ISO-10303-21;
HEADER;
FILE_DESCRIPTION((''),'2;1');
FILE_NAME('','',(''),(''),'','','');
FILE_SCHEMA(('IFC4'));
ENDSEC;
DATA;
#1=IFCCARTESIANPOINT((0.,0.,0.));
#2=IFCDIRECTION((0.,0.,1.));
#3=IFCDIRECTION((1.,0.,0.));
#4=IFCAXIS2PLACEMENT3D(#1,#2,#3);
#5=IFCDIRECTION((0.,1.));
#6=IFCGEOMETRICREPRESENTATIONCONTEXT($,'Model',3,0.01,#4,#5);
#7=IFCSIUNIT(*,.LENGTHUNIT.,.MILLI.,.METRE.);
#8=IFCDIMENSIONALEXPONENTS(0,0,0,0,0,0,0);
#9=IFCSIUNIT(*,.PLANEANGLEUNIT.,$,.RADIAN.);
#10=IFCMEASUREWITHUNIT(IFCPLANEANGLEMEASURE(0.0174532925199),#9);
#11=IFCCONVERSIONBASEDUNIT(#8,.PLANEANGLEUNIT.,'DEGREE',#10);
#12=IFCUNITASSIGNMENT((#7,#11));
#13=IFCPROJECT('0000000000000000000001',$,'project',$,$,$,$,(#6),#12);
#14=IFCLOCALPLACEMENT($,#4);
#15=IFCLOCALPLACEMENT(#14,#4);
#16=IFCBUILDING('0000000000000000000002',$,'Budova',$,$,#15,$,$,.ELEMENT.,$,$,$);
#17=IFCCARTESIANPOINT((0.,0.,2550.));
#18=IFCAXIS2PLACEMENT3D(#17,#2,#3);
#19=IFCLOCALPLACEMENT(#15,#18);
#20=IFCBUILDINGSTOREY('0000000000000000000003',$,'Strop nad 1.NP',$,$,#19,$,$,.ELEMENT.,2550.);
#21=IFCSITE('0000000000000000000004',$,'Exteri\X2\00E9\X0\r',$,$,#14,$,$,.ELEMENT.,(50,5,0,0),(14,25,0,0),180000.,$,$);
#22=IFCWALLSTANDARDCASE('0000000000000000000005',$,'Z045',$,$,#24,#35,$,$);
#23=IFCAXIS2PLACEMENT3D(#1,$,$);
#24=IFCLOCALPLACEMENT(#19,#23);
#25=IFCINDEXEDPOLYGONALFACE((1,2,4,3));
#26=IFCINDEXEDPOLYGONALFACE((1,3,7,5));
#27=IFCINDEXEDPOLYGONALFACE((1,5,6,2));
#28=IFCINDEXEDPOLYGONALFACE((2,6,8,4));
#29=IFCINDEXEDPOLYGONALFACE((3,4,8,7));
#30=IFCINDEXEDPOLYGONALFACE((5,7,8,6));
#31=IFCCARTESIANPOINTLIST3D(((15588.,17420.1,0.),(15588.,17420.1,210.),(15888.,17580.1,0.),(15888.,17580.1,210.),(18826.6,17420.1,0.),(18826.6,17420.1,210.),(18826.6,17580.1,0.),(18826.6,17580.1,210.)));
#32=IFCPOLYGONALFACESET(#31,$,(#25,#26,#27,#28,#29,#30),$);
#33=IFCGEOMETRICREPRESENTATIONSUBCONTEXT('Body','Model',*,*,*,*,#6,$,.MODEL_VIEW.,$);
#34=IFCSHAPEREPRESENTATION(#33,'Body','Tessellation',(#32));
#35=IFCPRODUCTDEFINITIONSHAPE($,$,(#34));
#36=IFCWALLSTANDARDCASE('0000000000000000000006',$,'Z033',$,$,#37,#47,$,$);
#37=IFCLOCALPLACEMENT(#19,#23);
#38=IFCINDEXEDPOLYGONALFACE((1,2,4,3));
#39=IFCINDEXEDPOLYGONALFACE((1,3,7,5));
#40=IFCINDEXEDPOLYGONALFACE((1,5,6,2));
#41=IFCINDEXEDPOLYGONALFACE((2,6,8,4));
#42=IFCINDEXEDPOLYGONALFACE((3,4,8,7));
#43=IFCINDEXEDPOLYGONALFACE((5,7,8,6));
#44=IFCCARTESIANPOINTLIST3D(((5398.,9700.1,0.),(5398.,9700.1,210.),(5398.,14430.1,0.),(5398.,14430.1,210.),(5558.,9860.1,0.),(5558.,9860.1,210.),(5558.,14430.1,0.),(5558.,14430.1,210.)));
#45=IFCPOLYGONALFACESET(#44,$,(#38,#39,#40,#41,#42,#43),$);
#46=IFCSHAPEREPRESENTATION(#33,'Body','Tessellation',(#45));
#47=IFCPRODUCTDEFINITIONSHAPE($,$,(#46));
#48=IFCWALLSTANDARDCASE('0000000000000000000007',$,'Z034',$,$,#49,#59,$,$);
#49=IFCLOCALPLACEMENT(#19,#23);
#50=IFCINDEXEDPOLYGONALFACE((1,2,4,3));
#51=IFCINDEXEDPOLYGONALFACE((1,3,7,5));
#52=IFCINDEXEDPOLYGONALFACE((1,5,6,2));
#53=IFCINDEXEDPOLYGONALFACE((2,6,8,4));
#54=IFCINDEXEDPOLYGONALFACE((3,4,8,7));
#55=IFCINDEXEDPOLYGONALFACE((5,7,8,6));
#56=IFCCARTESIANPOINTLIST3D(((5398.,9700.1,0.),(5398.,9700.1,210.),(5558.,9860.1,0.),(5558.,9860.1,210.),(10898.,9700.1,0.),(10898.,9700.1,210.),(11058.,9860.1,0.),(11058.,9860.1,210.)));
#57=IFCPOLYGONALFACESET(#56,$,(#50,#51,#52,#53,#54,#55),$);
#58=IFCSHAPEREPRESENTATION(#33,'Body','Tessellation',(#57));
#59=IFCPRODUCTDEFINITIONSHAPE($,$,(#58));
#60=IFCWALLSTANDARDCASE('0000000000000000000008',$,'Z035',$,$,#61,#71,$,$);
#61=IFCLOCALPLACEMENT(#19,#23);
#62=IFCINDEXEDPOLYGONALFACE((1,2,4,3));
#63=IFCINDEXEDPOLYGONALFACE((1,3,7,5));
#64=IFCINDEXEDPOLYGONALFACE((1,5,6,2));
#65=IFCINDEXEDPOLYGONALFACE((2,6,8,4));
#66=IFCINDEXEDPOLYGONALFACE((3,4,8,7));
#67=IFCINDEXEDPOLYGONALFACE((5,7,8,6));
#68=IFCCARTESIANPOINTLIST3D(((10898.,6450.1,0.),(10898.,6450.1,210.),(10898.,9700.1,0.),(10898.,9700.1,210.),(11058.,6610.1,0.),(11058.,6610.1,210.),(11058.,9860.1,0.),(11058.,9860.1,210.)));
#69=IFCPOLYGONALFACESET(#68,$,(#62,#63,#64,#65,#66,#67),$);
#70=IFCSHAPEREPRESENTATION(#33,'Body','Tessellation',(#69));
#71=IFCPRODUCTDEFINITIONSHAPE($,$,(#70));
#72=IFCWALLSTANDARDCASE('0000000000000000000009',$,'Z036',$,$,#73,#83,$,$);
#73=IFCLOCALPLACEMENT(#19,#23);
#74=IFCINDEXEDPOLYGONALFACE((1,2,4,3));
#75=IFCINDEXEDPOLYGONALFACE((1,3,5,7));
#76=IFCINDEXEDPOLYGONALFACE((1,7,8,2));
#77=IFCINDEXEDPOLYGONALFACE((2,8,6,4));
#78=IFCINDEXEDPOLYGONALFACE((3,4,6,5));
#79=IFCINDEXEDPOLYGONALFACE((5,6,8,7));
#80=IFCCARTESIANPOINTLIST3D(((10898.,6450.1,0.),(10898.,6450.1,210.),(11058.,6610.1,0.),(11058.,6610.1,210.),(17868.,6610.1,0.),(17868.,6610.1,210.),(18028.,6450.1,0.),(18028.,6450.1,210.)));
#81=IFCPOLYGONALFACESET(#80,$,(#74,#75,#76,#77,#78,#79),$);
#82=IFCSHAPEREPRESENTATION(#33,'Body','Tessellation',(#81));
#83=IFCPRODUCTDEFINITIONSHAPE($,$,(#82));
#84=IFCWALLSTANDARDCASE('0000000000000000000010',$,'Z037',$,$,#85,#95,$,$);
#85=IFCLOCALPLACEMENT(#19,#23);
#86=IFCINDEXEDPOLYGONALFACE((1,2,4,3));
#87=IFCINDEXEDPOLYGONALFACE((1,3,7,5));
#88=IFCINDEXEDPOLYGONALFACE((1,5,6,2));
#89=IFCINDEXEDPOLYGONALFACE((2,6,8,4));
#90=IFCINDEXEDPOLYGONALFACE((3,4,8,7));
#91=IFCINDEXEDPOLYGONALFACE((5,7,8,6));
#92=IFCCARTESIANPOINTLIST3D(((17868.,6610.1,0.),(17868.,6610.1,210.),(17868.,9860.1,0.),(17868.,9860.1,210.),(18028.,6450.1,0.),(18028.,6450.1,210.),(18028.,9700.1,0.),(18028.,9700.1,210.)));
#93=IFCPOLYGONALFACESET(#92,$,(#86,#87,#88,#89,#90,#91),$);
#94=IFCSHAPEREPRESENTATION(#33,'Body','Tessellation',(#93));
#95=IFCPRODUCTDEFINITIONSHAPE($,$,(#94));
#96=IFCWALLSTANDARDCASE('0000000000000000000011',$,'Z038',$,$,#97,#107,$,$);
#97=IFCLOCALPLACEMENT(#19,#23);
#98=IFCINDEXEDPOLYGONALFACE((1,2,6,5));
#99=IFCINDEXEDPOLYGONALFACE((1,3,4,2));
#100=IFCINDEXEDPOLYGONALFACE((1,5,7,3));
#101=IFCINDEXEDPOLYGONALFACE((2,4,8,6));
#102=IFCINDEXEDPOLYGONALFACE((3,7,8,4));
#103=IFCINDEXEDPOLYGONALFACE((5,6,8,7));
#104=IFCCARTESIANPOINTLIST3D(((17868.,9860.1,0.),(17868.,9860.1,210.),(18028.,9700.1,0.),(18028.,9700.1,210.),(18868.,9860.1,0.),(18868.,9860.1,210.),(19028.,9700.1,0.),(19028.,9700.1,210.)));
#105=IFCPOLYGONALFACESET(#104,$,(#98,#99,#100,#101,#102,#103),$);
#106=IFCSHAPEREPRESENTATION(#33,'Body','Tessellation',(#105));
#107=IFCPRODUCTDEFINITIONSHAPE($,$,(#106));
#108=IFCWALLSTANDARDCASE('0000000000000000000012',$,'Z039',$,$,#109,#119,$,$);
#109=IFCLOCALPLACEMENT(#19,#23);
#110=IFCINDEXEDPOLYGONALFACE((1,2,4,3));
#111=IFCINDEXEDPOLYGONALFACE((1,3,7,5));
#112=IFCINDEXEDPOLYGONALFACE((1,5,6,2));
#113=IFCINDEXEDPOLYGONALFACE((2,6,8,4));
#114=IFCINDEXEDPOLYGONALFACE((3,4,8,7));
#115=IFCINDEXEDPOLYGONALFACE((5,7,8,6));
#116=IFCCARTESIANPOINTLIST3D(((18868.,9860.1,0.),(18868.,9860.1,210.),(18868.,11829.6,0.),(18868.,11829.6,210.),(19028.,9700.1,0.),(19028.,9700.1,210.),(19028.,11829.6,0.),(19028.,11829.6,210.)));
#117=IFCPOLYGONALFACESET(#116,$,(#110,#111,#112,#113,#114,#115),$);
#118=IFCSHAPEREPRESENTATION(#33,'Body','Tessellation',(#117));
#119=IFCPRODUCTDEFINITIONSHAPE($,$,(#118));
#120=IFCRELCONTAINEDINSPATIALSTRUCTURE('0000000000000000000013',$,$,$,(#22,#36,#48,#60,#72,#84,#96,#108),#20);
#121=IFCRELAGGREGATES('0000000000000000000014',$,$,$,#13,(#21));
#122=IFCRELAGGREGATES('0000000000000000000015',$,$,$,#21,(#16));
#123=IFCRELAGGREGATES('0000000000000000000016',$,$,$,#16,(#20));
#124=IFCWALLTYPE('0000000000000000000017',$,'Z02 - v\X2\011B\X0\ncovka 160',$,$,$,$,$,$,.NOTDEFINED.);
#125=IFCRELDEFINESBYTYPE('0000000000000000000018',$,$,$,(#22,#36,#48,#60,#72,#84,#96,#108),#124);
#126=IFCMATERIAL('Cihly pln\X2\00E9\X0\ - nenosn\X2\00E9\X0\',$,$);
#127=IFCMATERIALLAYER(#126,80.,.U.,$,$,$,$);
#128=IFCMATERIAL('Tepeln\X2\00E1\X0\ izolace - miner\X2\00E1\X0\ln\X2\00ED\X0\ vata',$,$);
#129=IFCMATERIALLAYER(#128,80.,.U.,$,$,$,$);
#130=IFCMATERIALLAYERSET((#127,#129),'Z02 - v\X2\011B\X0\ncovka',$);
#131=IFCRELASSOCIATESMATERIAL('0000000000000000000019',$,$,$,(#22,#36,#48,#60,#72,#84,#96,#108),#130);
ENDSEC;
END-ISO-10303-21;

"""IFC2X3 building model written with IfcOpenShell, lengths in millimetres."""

from ifc_helpers import new_model, entity, si_unit, converted_unit, direction, frame, origin_with_axes, place, context, subcontext, project, spatial, polyline, outline, extrude, material, layer, layer_set, layer_usage, type_object, element, save


model = new_model("IFC2X3")

# Units and contexts
model_context = context("Model", 3, precision=0.01, world=origin_with_axes(), true_north=direction((0.0, 1.0)))
body_context = subcontext(model_context, "Body", "Model", "MODEL_VIEW")
ifc_project = project(units=[si_unit("LENGTHUNIT", "METRE", prefix="MILLI"), converted_unit("PLANEANGLEUNIT", "DEGREE", entity("IfcPlaneAngleMeasure", 0.0174532925199), si_unit("PLANEANGLEUNIT", "RADIAN"), dimensions=[0, 0, 0, 0, 0, 0, 0])], contexts=[model_context])

# Site, building, storey
site_placement = place(None, origin_with_axes())
site = spatial("IfcSite", under=ifc_project, at=site_placement, Name="Exteriér", CompositionType="ELEMENT", RefLatitude=(50, 5, 0, 0), RefLongitude=(14, 25, 0, 0), RefElevation=180000.0)
building_placement = place(site_placement, origin_with_axes())
building = spatial("IfcBuilding", under=site, at=building_placement, Name="Budova", CompositionType="ELEMENT")
storey_placement = place(building_placement, frame((0.0, 0.0, 2550.0), z_axis=(0.0, 0.0, 1.0), x_axis=(1.0, 0.0, 0.0)))
storey = spatial("IfcBuildingStorey", under=building, at=storey_placement, Name="Strop nad 1.NP", CompositionType="ELEMENT", Elevation=2550.0)

# Walls
ifc_material_1 = material(Name="Cihly plné - nenosné")
ifc_layer_1 = layer(ifc_material_1, 80.0, ventilated="UNKNOWN")
ifc_material_2 = material(Name="Tepelná izolace - minerální vata")
ifc_layer_2 = layer(ifc_material_2, 80.0, ventilated="UNKNOWN")
ifc_layer_set = layer_set([ifc_layer_1, ifc_layer_2], Name="Z02 - věncovka")
ifc_layer_usage_1 = layer_usage(ifc_layer_set, "AXIS2", "POSITIVE", 0.0)
wall_type = type_object("IfcWallType", Name="Z02 - věncovka 160", PredefinedType="NOTDEFINED")
wall_1_placement = place(storey_placement, frame((18826.6, 17580.1, 0.0), z_axis=(0.0, 0.0, 1.0), x_axis=(-1.0, 0.0, 0.0)))
element("IfcWallStandardCase", 1, at=wall_1_placement, inside=storey, type_object=wall_type, material=ifc_layer_usage_1, Name="Z045", context=body_context, shape_type="SweptSolid", body=[
    extrude(outline(polyline([(0.0, 0.0), (2938.6, 0.0), (3238.6, 160.0), (0.0, 160.0), (0.0, 0.0)])), origin_with_axes(), (0.0, 0.0, 1.0), 210.0),
])
ifc_layer_usage_2 = layer_usage(ifc_layer_set, "AXIS2", "POSITIVE", 0.0)
wall_2_placement = place(storey_placement, frame((5398.0, 14430.1, 0.0), z_axis=(0.0, 0.0, 1.0), x_axis=(0.0, -1.0, 0.0)))
element("IfcWallStandardCase", 2, at=wall_2_placement, inside=storey, type_object=wall_type, material=ifc_layer_usage_2, Name="Z033", context=body_context, shape_type="SweptSolid", body=[
    extrude(outline(polyline([(0.0, 0.0), (4730.0, 0.0), (4570.0, 160.0), (0.0, 160.0), (0.0, 0.0)])), origin_with_axes(), (0.0, 0.0, 1.0), 210.0),
])
ifc_layer_usage_3 = layer_usage(ifc_layer_set, "AXIS2", "POSITIVE", 0.0)
wall_3_placement = place(storey_placement, frame((5398.0, 9700.1, 0.0), z_axis=(0.0, 0.0, 1.0), x_axis=(1.0, 0.0, 0.0)))
element("IfcWallStandardCase", 3, at=wall_3_placement, inside=storey, type_object=wall_type, material=ifc_layer_usage_3, Name="Z034", context=body_context, shape_type="SweptSolid", body=[
    extrude(outline(polyline([(0.0, 0.0), (5500.0, 0.0), (5660.0, 160.0), (160.0, 160.0), (0.0, 0.0)])), origin_with_axes(), (0.0, 0.0, 1.0), 210.0),
])
ifc_layer_usage_4 = layer_usage(ifc_layer_set, "AXIS2", "POSITIVE", 0.0)
wall_4_placement = place(storey_placement, frame((10898.0, 9700.1, 0.0), z_axis=(0.0, 0.0, 1.0), x_axis=(0.0, -1.0, 0.0)))
element("IfcWallStandardCase", 4, at=wall_4_placement, inside=storey, type_object=wall_type, material=ifc_layer_usage_4, Name="Z035", context=body_context, shape_type="SweptSolid", body=[
    extrude(outline(polyline([(0.0, 0.0), (3250.0, 0.0), (3090.0, 160.0), (-160.0, 160.0), (0.0, 0.0)])), origin_with_axes(), (0.0, 0.0, 1.0), 210.0),
])
ifc_layer_usage_5 = layer_usage(ifc_layer_set, "AXIS2", "POSITIVE", 0.0)
wall_5_placement = place(storey_placement, frame((10898.0, 6450.1, 0.0), z_axis=(0.0, 0.0, 1.0), x_axis=(1.0, 0.0, 0.0)))
element("IfcWallStandardCase", 5, at=wall_5_placement, inside=storey, type_object=wall_type, material=ifc_layer_usage_5, Name="Z036", context=body_context, shape_type="SweptSolid", body=[
    extrude(outline(polyline([(0.0, 0.0), (7130.0, 0.0), (6970.0, 160.0), (160.0, 160.0), (0.0, 0.0)])), origin_with_axes(), (0.0, 0.0, 1.0), 210.0),
])
ifc_layer_usage_6 = layer_usage(ifc_layer_set, "AXIS2", "POSITIVE", 0.0)
wall_6_placement = place(storey_placement, frame((18028.0, 6450.1, 0.0), z_axis=(0.0, 0.0, 1.0), x_axis=(0.0, 1.0, 0.0)))
element("IfcWallStandardCase", 6, at=wall_6_placement, inside=storey, type_object=wall_type, material=ifc_layer_usage_6, Name="Z037", context=body_context, shape_type="SweptSolid", body=[
    extrude(outline(polyline([(0.0, 0.0), (3250.0, 0.0), (3410.0, 160.0), (160.0, 160.0), (0.0, 0.0)])), origin_with_axes(), (0.0, 0.0, 1.0), 210.0),
])
ifc_layer_usage_7 = layer_usage(ifc_layer_set, "AXIS2", "POSITIVE", 0.0)
wall_7_placement = place(storey_placement, frame((18028.0, 9700.1, 0.0), z_axis=(0.0, 0.0, 1.0), x_axis=(1.0, 0.0, 0.0)))
element("IfcWallStandardCase", 7, at=wall_7_placement, inside=storey, type_object=wall_type, material=ifc_layer_usage_7, Name="Z038", context=body_context, shape_type="SweptSolid", body=[
    extrude(outline(polyline([(0.0, 0.0), (1000.0, 0.0), (840.0, 160.0), (-160.0, 160.0), (0.0, 0.0)])), origin_with_axes(), (0.0, 0.0, 1.0), 210.0),
])
ifc_layer_usage_8 = layer_usage(ifc_layer_set, "AXIS2", "POSITIVE", 0.0)
wall_8_placement = place(storey_placement, frame((19028.0, 9700.1, 0.0), z_axis=(0.0, 0.0, 1.0), x_axis=(0.0, 1.0, 0.0)))
element("IfcWallStandardCase", 8, at=wall_8_placement, inside=storey, type_object=wall_type, material=ifc_layer_usage_8, Name="Z039", context=body_context, shape_type="SweptSolid", body=[
    extrude(outline(polyline([(0.0, 0.0), (2129.5, 0.0), (2129.5, 160.0), (160.0, 160.0), (0.0, 0.0)])), origin_with_axes(), (0.0, 0.0, 1.0), 210.0),
])

save(model, "model.ifc")
